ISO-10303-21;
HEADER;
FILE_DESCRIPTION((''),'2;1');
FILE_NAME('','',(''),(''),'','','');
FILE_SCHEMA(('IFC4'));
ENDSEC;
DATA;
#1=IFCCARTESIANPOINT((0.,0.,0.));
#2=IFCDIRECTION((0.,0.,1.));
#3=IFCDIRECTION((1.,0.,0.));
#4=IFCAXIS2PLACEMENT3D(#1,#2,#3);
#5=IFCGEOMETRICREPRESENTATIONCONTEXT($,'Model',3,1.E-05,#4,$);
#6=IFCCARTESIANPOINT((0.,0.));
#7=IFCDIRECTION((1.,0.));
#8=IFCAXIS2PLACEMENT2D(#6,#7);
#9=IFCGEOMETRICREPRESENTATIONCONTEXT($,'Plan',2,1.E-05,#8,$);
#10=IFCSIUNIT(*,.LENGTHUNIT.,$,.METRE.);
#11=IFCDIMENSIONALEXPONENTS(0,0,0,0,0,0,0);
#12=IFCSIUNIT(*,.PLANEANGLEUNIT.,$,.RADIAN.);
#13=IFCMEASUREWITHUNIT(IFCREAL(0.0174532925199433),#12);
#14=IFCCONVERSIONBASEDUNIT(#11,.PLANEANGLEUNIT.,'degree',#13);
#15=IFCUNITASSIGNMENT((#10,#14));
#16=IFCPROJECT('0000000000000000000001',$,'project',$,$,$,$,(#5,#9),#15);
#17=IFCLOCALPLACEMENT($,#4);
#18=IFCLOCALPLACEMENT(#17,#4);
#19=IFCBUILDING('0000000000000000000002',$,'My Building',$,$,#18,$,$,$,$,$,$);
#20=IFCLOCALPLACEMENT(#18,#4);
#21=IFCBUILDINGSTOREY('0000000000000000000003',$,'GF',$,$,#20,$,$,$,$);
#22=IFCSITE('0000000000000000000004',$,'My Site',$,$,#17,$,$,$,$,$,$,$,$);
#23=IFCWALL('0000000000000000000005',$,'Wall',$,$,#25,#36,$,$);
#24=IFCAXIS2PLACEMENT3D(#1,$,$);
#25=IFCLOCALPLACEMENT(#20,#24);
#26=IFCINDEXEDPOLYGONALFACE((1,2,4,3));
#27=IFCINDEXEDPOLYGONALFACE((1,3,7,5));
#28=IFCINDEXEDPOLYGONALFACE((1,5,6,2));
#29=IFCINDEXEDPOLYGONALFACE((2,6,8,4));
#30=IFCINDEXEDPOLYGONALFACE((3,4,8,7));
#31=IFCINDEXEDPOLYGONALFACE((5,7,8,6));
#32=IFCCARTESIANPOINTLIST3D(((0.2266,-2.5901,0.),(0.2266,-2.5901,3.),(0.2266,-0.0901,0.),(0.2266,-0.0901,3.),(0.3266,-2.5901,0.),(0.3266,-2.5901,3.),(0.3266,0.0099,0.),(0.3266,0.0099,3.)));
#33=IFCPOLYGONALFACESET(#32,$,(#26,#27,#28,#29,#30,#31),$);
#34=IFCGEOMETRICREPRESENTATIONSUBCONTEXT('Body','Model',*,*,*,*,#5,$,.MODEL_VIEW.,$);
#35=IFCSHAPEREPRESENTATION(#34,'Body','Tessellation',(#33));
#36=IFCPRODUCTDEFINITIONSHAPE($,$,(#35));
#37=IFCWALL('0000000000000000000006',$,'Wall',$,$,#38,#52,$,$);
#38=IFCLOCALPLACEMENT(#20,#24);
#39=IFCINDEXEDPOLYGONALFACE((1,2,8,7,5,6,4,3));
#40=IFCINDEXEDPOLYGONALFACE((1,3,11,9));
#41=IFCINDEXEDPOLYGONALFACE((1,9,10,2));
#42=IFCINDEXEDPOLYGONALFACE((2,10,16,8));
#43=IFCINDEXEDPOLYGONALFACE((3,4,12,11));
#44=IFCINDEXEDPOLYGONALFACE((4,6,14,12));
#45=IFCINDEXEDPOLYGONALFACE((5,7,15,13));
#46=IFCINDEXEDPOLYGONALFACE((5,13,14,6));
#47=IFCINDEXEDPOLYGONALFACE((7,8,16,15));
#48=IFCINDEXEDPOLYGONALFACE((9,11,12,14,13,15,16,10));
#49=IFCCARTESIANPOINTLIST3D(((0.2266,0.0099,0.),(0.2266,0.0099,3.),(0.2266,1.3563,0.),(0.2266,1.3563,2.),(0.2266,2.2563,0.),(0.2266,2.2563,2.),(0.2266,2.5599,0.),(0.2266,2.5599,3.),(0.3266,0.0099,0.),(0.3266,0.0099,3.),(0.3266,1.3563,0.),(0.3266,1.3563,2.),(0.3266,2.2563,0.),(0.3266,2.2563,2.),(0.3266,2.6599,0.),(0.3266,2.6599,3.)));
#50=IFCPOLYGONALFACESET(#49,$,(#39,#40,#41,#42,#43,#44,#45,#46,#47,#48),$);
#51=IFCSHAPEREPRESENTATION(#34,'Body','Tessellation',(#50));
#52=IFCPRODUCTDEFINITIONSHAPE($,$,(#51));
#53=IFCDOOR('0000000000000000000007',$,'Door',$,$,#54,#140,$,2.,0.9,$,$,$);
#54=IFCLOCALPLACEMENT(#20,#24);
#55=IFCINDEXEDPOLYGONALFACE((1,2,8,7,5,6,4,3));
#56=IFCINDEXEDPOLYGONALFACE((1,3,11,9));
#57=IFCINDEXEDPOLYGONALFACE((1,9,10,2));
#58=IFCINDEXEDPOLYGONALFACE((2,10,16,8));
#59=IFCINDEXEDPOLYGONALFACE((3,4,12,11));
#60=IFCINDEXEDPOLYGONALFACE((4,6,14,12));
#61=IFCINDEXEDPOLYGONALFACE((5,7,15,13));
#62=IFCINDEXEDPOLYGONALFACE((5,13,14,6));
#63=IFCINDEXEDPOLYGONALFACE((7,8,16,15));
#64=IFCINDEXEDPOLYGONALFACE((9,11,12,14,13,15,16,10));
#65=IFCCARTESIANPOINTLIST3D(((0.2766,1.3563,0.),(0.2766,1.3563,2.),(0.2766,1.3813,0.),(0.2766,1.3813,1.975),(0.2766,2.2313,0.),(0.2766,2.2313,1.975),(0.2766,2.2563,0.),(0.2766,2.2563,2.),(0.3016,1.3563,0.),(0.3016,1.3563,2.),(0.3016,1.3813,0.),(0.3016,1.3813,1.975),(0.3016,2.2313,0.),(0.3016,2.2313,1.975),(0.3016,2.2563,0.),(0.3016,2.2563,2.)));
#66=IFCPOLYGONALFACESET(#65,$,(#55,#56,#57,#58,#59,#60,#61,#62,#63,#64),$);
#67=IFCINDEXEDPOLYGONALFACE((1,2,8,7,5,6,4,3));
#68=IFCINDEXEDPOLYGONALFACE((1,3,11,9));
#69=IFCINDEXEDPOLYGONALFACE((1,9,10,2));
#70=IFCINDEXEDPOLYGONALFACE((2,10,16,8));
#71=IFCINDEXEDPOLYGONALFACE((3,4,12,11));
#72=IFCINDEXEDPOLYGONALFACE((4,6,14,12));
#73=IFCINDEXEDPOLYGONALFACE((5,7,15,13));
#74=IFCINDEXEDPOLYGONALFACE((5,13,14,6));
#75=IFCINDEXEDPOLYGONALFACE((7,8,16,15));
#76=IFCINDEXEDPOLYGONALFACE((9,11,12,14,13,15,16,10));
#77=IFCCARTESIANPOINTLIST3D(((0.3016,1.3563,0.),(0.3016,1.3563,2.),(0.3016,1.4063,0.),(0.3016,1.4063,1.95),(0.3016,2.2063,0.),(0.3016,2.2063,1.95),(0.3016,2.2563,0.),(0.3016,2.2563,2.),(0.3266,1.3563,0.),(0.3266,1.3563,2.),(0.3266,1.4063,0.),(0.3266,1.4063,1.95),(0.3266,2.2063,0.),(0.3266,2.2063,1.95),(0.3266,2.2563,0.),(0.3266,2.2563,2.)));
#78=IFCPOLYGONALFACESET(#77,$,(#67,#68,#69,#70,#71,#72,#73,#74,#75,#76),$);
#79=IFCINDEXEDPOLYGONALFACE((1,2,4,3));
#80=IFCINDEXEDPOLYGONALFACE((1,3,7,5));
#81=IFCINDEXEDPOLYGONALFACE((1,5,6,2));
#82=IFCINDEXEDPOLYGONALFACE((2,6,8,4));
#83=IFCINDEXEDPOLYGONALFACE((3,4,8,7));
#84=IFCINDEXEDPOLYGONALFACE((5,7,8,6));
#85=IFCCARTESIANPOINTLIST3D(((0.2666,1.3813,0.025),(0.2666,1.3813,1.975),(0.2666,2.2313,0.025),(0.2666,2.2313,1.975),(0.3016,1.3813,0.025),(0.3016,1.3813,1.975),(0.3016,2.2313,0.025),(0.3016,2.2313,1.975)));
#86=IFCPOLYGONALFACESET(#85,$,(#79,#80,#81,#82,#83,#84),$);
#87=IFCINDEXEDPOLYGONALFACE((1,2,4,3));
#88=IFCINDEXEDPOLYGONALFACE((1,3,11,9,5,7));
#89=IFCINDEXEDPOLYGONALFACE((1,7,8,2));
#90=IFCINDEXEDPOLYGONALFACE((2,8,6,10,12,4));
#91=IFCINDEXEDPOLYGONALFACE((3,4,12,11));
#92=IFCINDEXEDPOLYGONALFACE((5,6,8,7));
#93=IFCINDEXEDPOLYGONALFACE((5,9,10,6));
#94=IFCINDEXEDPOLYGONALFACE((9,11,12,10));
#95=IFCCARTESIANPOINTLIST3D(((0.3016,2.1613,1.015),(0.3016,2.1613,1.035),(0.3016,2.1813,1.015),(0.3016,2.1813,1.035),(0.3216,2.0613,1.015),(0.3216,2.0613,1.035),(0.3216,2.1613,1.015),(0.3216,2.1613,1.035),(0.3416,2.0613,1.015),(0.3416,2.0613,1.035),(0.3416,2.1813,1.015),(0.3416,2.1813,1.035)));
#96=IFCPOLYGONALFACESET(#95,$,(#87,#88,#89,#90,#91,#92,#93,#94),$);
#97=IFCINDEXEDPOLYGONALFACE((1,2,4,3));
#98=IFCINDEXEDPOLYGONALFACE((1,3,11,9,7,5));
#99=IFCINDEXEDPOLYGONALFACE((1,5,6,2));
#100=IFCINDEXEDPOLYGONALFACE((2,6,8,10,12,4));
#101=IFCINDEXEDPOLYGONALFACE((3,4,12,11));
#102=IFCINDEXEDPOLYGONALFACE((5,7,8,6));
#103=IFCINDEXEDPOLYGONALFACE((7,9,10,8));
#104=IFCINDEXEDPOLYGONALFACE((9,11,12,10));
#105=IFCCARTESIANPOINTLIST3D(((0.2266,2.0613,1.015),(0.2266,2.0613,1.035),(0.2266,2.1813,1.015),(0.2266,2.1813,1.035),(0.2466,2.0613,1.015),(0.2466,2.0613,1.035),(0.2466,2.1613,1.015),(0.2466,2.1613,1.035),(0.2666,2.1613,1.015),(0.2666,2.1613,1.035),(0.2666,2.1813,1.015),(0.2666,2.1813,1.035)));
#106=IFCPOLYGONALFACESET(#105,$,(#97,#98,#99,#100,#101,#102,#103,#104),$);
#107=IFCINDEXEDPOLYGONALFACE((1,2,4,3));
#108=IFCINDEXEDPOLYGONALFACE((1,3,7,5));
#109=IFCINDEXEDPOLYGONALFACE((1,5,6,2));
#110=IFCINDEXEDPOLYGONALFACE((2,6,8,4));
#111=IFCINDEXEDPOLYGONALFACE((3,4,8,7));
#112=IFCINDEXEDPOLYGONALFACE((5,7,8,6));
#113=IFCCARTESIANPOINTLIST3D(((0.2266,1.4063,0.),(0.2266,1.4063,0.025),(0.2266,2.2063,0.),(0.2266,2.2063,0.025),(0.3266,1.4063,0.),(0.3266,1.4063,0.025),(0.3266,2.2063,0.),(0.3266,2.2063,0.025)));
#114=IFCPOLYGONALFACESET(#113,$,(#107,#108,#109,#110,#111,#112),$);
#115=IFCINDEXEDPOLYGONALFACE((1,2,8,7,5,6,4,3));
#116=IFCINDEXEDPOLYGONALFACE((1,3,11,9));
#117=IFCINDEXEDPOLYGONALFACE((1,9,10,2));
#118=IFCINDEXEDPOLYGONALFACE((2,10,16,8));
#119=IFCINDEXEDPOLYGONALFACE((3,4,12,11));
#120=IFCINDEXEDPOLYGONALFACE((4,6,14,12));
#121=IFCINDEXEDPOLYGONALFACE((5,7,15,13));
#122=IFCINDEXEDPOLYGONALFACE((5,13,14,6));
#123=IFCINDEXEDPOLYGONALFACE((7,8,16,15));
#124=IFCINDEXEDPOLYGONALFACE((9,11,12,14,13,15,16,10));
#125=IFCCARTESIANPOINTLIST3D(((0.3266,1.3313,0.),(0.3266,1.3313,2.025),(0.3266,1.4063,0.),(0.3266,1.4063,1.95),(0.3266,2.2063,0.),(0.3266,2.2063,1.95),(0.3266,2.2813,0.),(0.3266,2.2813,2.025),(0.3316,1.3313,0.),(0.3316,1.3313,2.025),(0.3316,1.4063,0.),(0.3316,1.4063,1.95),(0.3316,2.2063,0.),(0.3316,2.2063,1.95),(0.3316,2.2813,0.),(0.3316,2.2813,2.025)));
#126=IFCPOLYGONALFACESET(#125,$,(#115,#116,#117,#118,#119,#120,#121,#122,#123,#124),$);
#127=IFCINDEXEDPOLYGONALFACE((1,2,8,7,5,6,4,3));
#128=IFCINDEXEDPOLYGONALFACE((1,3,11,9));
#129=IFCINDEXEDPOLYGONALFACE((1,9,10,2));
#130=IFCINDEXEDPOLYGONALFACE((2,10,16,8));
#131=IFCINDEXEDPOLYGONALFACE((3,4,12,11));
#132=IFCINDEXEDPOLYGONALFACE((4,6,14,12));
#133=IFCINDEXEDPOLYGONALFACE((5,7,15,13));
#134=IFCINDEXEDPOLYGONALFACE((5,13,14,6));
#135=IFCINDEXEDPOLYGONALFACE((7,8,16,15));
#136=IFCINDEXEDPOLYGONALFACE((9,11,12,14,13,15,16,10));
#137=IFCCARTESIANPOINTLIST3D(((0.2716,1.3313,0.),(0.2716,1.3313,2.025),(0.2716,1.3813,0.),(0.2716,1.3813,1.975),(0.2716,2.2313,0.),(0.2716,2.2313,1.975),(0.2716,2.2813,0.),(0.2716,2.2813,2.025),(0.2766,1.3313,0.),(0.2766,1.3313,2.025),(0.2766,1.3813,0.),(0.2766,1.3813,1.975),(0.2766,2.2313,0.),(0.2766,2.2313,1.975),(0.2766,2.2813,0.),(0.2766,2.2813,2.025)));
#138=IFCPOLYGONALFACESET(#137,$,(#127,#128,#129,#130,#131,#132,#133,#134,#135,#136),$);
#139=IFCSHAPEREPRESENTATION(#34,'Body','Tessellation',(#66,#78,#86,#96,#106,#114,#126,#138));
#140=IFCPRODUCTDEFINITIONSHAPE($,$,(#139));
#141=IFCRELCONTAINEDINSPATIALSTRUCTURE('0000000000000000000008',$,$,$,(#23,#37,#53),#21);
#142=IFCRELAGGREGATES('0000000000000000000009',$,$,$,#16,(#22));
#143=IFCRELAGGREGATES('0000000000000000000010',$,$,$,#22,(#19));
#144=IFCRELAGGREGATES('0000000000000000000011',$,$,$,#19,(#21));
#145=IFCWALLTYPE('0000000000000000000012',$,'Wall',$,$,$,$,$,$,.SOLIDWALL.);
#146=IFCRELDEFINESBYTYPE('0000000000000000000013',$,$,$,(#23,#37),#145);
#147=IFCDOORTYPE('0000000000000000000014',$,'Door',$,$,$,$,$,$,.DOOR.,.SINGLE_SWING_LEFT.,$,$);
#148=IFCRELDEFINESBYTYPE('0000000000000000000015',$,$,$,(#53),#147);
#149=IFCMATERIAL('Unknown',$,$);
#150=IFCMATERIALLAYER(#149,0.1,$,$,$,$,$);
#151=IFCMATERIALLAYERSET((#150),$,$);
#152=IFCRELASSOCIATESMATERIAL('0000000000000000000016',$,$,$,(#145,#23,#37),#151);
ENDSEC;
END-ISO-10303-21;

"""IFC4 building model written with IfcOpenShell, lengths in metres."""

from ifc_helpers import new_model, entity, si_unit, converted_unit, frame, origin_with_axes, origin_2d_with_axis, place, context, subcontext, project, spatial, line, indexed_curve, outline, extrude, shape, source, transform, mapped, material, layer, layer_set, layer_usage, type_object, type_shapes, element, fill, save


model = new_model("IFC4")

# Units and contexts
model_context = context("Model", 3, precision=1e-05, world=origin_with_axes())
plan_context = context("Plan", 2, precision=1e-05, world=origin_2d_with_axis())
body_context_1 = subcontext(model_context, "Body", "Model", "MODEL_VIEW")
body_context_2 = subcontext(plan_context, "Body", "Plan", "PLAN_VIEW")
ifc_project = project(units=[si_unit("LENGTHUNIT", "METRE"), converted_unit("PLANEANGLEUNIT", "degree", entity("IfcReal", 0.0174532925199433), si_unit("PLANEANGLEUNIT", "RADIAN"), dimensions=[0, 0, 0, 0, 0, 0, 0])], contexts=[model_context, plan_context])

# Site, building, storey
site_placement = place(None, origin_with_axes())
site = spatial("IfcSite", under=ifc_project, at=site_placement, Name="My Site")
building_placement = place(site_placement, origin_with_axes())
building = spatial("IfcBuilding", under=site, at=building_placement, Name="My Building")
storey_placement = place(building_placement, origin_with_axes())
storey = spatial("IfcBuildingStorey", under=building, at=storey_placement, Name="GF")

# Shared definitions
ifc_material_1 = material(Name="Unknown")

# Shared definitions
ifc_layer_1 = layer(ifc_material_1, 0.1)
ifc_layer_set_1 = layer_set([ifc_layer_1])
wall_type = type_object("IfcWallType", Name="Wall", PredefinedType="SOLIDWALL", material=ifc_layer_set_1)
shared_shape_1 = source(origin_with_axes(), body_context_1, "Body", "SweptSolid", [
    extrude(outline(indexed_curve([(0.0, 0.0), (0.9, 0.0), (0.9, 2.0), (0.0, 2.0)], segments=[line(1, 2, 3, 4, 1)])), frame((0.0, -0.6, 0.0), z_axis=(0.0, -1.0, 0.0), x_axis=(1.0, 0.0, 0.0)), (0.0, 0.0, -1.0), 1.2),
])
door_type = type_object("IfcDoorType", Name="Door", OperationType="SINGLE_SWING_LEFT", PredefinedType="DOOR")
shared_shape_2 = source(origin_with_axes(), body_context_1, "Body", "SweptSolid", [
    extrude(outline(indexed_curve([(0.0, 0.0), (0.0, 2.0), (0.9, 2.0), (0.9, 0.0), (0.875, 0.0), (0.875, 1.975), (0.025, 1.975), (0.025, 0.0)], segments=[line(1, 2, 3, 4, 5, 6, 7, 8, 1)])), frame((0.0, 0.025, 0.0), z_axis=(0.0, -1.0, 0.0), x_axis=(1.0, 0.0, 0.0)), (0.0, 0.0, -1.0), 0.025),
    extrude(outline(indexed_curve([(0.0, 0.0), (0.0, 2.0), (0.9, 2.0), (0.9, 0.0), (0.85, 0.0), (0.85, 1.95), (0.05, 1.95), (0.05, 0.0)], segments=[line(1, 2, 3, 4, 5, 6, 7, 8, 1)])), frame((0.0, 0.0, 0.0), z_axis=(0.0, -1.0, 0.0), x_axis=(1.0, 0.0, 0.0)), (0.0, 0.0, -1.0), 0.025),
    extrude(outline(indexed_curve([(0.0, 0.0), (0.85, 0.0), (0.85, 0.035), (0.0, 0.035)], segments=[line(1, 2, 3, 4, 1)])), frame((0.025, 0.025, 0.025), z_axis=(0.0, 0.0, 1.0), x_axis=(1.0, 0.0, 0.0)), (0.0, 0.0, 1.0), 1.95),
    extrude(outline(indexed_curve([(0.0, 0.0), (0.0, -0.04), (-0.12, -0.04), (-0.12, -0.02), (-0.02, -0.02), (-0.02, 0.0)], segments=[line(1, 2, 3, 4, 5, 6, 1)])), frame((0.825, 0.025, 1.015), z_axis=(0.0, 0.0, 1.0), x_axis=(1.0, 0.0, 0.0)), (0.0, 0.0, 1.0), 0.02),
    extrude(outline(indexed_curve([(0.0, 0.0), (0.0, 0.04), (-0.12, 0.04), (-0.12, 0.02), (-0.02, 0.02), (-0.02, 0.0)], segments=[line(1, 2, 3, 4, 5, 6, 1)])), frame((0.825, 0.06, 1.015), z_axis=(0.0, 0.0, 1.0), x_axis=(1.0, 0.0, 0.0)), (0.0, 0.0, 1.0), 0.02),
    extrude(outline(indexed_curve([(0.0, 0.0), (0.8, 0.0), (0.8, 0.1), (0.0, 0.1)], segments=[line(1, 2, 3, 4, 1)])), frame((0.05, 0.0, 0.0), z_axis=(0.0, 0.0, 1.0), x_axis=(1.0, 0.0, 0.0)), (0.0, 0.0, 1.0), 0.025),
    extrude(outline(indexed_curve([(0.0, 0.0), (0.0, 2.025), (0.95, 2.025), (0.95, 0.0), (0.875, 0.0), (0.875, 1.95), (0.075, 1.95), (0.075, 0.0)], segments=[line(1, 2, 3, 4, 5, 6, 7, 8, 1)])), frame((-0.025, -0.005, 0.0), z_axis=(0.0, -1.0, 0.0), x_axis=(1.0, 0.0, 0.0)), (0.0, 0.0, -1.0), 0.005),
    extrude(outline(indexed_curve([(0.0, 0.0), (0.0, 2.025), (0.95, 2.025), (0.95, 0.0), (0.9, 0.0), (0.9, 1.975), (0.05, 1.975), (0.05, 0.0)], segments=[line(1, 2, 3, 4, 5, 6, 7, 8, 1)])), frame((-0.025, 0.05, 0.0), z_axis=(0.0, -1.0, 0.0), x_axis=(1.0, 0.0, 0.0)), (0.0, 0.0, -1.0), 0.005),
])
shared_shape_3 = source(origin_with_axes(), body_context_2, "Body", "Curve2D", [
    entity("IfcIndexedPolyCurve", entity("IfcCartesianPointList2D", [[0.0, 0.0], [0.0, 0.05], [0.025, 0.05], [0.025, 0.025], [0.05, 0.025], [0.05, 0.0]]), [entity("IfcLineIndex", [1, 2, 3, 4, 5, 6, 1])]),
    entity("IfcIndexedPolyCurve", entity("IfcCartesianPointList2D", [[0.9, 0.0], [0.9, 0.05], [0.875, 0.05], [0.875, 0.025], [0.85, 0.025], [0.85, 0.0]]), [entity("IfcLineIndex", [1, 2, 3, 4, 5, 6, 1])]),
    entity("IfcTrimmedCurve", entity("IfcEllipse", entity("IfcAxis2Placement2D", entity("IfcCartesianPoint", [0.06, 0.05]), entity("IfcDirection", [1.0, 0.0])), 0.815, 0.85), [entity("IfcCartesianPoint", [0.875, 0.05])], [entity("IfcCartesianPoint", [0.06, 0.9])], True, "CARTESIAN"),
    entity("IfcIndexedPolyCurve", entity("IfcCartesianPointList2D", [[0.025, 0.05], [0.06, 0.05], [0.06, 0.9], [0.025, 0.9]]), [entity("IfcLineIndex", [1, 2, 3, 4, 1])]),
])
type_shapes(door_type, [shared_shape_2, shared_shape_3])

# Wall
ifc_layer_usage_1 = layer_usage(ifc_layer_set_1, "AXIS2", "POSITIVE", 0.0)
wall_1_placement = place(storey_placement, frame((0.2266, -0.0901, 0.0), z_axis=(0.0, 0.0, 1.0), x_axis=(0.0, -1.0, 0.0)))
element("IfcWall", 1, at=wall_1_placement, inside=storey, type_object=wall_type, material=ifc_layer_usage_1, Name="Wall", context=body_context_1, shape_type="SweptSolid", body=[
    extrude(outline(indexed_curve([(0.0, 0.0), (-0.1, 0.1), (2.5, 0.1), (2.5, 0.0)], segments=[line(1, 2, 3, 4, 1)])), origin_with_axes(), (0.0, 0.0, 1.0), 3.0),
])

# Wall, opening, door
ifc_layer_usage_2 = layer_usage(ifc_layer_set_1, "AXIS2", "POSITIVE", 0.0)
wall_2_placement = place(storey_placement, frame((0.3266, 0.0099, 0.0), z_axis=(0.0, 0.0, 1.0), x_axis=(0.0, 1.0, 0.0)))
wall_2 = element("IfcWall", 2, at=wall_2_placement, inside=storey, type_object=wall_type, material=ifc_layer_usage_2, Name="Wall", context=body_context_1, shape_type="SweptSolid", body=[
    extrude(outline(indexed_curve([(0.0, 0.0), (0.0, 0.1), (2.55, 0.1), (2.65, 0.0)], segments=[line(1, 2, 3, 4, 1)])), origin_with_axes(), (0.0, 0.0, 1.0), 3.0),
])
opening_1_placement = place(wall_2_placement, frame((1.3464, 0.0, 0.0), z_axis=(0.0, 0.0, 1.0), x_axis=(1.0, 0.0, 0.0)))
opening_1 = element("IfcOpeningElement", 3, at=opening_1_placement, cuts=wall_2, PredefinedType="OPENING", context=body_context_1, shape_type="MappedRepresentation", body=[
    mapped(shared_shape_1, transform((0.0, 0.0, 0.0), x_axis=(1.0, 0.0, 0.0), y_axis=(0.0, 1.0, 0.0), z_axis=(0.0, 0.0, 1.0), scale=1.0)),
])
door_1_placement = place(opening_1_placement, frame((0.0, 0.0, 0.0), z_axis=(0.0, 0.0, 1.0), x_axis=(1.0, 0.0, 0.0)))
door_1 = element("IfcDoor", 4, at=door_1_placement, inside=storey, type_object=door_type, Name="Door", OverallHeight=2.0, OverallWidth=0.9, shapes=[
    shape(body_context_1, "Body", "MappedRepresentation", [mapped(shared_shape_2, transform((0.0, 0.0, 0.0), x_axis=(1.0, 0.0, 0.0), y_axis=(0.0, 1.0, 0.0), z_axis=(0.0, 0.0, 1.0), scale=1.0))]),
    shape(body_context_2, "Body", "MappedRepresentation", [mapped(shared_shape_3, transform((0.0, 0.0, 0.0), x_axis=(1.0, 0.0, 0.0), y_axis=(0.0, 1.0, 0.0), z_axis=(0.0, 0.0, 1.0), scale=1.0))]),
])
fill(opening_1, door_1)

save(model, "model.ifc")
